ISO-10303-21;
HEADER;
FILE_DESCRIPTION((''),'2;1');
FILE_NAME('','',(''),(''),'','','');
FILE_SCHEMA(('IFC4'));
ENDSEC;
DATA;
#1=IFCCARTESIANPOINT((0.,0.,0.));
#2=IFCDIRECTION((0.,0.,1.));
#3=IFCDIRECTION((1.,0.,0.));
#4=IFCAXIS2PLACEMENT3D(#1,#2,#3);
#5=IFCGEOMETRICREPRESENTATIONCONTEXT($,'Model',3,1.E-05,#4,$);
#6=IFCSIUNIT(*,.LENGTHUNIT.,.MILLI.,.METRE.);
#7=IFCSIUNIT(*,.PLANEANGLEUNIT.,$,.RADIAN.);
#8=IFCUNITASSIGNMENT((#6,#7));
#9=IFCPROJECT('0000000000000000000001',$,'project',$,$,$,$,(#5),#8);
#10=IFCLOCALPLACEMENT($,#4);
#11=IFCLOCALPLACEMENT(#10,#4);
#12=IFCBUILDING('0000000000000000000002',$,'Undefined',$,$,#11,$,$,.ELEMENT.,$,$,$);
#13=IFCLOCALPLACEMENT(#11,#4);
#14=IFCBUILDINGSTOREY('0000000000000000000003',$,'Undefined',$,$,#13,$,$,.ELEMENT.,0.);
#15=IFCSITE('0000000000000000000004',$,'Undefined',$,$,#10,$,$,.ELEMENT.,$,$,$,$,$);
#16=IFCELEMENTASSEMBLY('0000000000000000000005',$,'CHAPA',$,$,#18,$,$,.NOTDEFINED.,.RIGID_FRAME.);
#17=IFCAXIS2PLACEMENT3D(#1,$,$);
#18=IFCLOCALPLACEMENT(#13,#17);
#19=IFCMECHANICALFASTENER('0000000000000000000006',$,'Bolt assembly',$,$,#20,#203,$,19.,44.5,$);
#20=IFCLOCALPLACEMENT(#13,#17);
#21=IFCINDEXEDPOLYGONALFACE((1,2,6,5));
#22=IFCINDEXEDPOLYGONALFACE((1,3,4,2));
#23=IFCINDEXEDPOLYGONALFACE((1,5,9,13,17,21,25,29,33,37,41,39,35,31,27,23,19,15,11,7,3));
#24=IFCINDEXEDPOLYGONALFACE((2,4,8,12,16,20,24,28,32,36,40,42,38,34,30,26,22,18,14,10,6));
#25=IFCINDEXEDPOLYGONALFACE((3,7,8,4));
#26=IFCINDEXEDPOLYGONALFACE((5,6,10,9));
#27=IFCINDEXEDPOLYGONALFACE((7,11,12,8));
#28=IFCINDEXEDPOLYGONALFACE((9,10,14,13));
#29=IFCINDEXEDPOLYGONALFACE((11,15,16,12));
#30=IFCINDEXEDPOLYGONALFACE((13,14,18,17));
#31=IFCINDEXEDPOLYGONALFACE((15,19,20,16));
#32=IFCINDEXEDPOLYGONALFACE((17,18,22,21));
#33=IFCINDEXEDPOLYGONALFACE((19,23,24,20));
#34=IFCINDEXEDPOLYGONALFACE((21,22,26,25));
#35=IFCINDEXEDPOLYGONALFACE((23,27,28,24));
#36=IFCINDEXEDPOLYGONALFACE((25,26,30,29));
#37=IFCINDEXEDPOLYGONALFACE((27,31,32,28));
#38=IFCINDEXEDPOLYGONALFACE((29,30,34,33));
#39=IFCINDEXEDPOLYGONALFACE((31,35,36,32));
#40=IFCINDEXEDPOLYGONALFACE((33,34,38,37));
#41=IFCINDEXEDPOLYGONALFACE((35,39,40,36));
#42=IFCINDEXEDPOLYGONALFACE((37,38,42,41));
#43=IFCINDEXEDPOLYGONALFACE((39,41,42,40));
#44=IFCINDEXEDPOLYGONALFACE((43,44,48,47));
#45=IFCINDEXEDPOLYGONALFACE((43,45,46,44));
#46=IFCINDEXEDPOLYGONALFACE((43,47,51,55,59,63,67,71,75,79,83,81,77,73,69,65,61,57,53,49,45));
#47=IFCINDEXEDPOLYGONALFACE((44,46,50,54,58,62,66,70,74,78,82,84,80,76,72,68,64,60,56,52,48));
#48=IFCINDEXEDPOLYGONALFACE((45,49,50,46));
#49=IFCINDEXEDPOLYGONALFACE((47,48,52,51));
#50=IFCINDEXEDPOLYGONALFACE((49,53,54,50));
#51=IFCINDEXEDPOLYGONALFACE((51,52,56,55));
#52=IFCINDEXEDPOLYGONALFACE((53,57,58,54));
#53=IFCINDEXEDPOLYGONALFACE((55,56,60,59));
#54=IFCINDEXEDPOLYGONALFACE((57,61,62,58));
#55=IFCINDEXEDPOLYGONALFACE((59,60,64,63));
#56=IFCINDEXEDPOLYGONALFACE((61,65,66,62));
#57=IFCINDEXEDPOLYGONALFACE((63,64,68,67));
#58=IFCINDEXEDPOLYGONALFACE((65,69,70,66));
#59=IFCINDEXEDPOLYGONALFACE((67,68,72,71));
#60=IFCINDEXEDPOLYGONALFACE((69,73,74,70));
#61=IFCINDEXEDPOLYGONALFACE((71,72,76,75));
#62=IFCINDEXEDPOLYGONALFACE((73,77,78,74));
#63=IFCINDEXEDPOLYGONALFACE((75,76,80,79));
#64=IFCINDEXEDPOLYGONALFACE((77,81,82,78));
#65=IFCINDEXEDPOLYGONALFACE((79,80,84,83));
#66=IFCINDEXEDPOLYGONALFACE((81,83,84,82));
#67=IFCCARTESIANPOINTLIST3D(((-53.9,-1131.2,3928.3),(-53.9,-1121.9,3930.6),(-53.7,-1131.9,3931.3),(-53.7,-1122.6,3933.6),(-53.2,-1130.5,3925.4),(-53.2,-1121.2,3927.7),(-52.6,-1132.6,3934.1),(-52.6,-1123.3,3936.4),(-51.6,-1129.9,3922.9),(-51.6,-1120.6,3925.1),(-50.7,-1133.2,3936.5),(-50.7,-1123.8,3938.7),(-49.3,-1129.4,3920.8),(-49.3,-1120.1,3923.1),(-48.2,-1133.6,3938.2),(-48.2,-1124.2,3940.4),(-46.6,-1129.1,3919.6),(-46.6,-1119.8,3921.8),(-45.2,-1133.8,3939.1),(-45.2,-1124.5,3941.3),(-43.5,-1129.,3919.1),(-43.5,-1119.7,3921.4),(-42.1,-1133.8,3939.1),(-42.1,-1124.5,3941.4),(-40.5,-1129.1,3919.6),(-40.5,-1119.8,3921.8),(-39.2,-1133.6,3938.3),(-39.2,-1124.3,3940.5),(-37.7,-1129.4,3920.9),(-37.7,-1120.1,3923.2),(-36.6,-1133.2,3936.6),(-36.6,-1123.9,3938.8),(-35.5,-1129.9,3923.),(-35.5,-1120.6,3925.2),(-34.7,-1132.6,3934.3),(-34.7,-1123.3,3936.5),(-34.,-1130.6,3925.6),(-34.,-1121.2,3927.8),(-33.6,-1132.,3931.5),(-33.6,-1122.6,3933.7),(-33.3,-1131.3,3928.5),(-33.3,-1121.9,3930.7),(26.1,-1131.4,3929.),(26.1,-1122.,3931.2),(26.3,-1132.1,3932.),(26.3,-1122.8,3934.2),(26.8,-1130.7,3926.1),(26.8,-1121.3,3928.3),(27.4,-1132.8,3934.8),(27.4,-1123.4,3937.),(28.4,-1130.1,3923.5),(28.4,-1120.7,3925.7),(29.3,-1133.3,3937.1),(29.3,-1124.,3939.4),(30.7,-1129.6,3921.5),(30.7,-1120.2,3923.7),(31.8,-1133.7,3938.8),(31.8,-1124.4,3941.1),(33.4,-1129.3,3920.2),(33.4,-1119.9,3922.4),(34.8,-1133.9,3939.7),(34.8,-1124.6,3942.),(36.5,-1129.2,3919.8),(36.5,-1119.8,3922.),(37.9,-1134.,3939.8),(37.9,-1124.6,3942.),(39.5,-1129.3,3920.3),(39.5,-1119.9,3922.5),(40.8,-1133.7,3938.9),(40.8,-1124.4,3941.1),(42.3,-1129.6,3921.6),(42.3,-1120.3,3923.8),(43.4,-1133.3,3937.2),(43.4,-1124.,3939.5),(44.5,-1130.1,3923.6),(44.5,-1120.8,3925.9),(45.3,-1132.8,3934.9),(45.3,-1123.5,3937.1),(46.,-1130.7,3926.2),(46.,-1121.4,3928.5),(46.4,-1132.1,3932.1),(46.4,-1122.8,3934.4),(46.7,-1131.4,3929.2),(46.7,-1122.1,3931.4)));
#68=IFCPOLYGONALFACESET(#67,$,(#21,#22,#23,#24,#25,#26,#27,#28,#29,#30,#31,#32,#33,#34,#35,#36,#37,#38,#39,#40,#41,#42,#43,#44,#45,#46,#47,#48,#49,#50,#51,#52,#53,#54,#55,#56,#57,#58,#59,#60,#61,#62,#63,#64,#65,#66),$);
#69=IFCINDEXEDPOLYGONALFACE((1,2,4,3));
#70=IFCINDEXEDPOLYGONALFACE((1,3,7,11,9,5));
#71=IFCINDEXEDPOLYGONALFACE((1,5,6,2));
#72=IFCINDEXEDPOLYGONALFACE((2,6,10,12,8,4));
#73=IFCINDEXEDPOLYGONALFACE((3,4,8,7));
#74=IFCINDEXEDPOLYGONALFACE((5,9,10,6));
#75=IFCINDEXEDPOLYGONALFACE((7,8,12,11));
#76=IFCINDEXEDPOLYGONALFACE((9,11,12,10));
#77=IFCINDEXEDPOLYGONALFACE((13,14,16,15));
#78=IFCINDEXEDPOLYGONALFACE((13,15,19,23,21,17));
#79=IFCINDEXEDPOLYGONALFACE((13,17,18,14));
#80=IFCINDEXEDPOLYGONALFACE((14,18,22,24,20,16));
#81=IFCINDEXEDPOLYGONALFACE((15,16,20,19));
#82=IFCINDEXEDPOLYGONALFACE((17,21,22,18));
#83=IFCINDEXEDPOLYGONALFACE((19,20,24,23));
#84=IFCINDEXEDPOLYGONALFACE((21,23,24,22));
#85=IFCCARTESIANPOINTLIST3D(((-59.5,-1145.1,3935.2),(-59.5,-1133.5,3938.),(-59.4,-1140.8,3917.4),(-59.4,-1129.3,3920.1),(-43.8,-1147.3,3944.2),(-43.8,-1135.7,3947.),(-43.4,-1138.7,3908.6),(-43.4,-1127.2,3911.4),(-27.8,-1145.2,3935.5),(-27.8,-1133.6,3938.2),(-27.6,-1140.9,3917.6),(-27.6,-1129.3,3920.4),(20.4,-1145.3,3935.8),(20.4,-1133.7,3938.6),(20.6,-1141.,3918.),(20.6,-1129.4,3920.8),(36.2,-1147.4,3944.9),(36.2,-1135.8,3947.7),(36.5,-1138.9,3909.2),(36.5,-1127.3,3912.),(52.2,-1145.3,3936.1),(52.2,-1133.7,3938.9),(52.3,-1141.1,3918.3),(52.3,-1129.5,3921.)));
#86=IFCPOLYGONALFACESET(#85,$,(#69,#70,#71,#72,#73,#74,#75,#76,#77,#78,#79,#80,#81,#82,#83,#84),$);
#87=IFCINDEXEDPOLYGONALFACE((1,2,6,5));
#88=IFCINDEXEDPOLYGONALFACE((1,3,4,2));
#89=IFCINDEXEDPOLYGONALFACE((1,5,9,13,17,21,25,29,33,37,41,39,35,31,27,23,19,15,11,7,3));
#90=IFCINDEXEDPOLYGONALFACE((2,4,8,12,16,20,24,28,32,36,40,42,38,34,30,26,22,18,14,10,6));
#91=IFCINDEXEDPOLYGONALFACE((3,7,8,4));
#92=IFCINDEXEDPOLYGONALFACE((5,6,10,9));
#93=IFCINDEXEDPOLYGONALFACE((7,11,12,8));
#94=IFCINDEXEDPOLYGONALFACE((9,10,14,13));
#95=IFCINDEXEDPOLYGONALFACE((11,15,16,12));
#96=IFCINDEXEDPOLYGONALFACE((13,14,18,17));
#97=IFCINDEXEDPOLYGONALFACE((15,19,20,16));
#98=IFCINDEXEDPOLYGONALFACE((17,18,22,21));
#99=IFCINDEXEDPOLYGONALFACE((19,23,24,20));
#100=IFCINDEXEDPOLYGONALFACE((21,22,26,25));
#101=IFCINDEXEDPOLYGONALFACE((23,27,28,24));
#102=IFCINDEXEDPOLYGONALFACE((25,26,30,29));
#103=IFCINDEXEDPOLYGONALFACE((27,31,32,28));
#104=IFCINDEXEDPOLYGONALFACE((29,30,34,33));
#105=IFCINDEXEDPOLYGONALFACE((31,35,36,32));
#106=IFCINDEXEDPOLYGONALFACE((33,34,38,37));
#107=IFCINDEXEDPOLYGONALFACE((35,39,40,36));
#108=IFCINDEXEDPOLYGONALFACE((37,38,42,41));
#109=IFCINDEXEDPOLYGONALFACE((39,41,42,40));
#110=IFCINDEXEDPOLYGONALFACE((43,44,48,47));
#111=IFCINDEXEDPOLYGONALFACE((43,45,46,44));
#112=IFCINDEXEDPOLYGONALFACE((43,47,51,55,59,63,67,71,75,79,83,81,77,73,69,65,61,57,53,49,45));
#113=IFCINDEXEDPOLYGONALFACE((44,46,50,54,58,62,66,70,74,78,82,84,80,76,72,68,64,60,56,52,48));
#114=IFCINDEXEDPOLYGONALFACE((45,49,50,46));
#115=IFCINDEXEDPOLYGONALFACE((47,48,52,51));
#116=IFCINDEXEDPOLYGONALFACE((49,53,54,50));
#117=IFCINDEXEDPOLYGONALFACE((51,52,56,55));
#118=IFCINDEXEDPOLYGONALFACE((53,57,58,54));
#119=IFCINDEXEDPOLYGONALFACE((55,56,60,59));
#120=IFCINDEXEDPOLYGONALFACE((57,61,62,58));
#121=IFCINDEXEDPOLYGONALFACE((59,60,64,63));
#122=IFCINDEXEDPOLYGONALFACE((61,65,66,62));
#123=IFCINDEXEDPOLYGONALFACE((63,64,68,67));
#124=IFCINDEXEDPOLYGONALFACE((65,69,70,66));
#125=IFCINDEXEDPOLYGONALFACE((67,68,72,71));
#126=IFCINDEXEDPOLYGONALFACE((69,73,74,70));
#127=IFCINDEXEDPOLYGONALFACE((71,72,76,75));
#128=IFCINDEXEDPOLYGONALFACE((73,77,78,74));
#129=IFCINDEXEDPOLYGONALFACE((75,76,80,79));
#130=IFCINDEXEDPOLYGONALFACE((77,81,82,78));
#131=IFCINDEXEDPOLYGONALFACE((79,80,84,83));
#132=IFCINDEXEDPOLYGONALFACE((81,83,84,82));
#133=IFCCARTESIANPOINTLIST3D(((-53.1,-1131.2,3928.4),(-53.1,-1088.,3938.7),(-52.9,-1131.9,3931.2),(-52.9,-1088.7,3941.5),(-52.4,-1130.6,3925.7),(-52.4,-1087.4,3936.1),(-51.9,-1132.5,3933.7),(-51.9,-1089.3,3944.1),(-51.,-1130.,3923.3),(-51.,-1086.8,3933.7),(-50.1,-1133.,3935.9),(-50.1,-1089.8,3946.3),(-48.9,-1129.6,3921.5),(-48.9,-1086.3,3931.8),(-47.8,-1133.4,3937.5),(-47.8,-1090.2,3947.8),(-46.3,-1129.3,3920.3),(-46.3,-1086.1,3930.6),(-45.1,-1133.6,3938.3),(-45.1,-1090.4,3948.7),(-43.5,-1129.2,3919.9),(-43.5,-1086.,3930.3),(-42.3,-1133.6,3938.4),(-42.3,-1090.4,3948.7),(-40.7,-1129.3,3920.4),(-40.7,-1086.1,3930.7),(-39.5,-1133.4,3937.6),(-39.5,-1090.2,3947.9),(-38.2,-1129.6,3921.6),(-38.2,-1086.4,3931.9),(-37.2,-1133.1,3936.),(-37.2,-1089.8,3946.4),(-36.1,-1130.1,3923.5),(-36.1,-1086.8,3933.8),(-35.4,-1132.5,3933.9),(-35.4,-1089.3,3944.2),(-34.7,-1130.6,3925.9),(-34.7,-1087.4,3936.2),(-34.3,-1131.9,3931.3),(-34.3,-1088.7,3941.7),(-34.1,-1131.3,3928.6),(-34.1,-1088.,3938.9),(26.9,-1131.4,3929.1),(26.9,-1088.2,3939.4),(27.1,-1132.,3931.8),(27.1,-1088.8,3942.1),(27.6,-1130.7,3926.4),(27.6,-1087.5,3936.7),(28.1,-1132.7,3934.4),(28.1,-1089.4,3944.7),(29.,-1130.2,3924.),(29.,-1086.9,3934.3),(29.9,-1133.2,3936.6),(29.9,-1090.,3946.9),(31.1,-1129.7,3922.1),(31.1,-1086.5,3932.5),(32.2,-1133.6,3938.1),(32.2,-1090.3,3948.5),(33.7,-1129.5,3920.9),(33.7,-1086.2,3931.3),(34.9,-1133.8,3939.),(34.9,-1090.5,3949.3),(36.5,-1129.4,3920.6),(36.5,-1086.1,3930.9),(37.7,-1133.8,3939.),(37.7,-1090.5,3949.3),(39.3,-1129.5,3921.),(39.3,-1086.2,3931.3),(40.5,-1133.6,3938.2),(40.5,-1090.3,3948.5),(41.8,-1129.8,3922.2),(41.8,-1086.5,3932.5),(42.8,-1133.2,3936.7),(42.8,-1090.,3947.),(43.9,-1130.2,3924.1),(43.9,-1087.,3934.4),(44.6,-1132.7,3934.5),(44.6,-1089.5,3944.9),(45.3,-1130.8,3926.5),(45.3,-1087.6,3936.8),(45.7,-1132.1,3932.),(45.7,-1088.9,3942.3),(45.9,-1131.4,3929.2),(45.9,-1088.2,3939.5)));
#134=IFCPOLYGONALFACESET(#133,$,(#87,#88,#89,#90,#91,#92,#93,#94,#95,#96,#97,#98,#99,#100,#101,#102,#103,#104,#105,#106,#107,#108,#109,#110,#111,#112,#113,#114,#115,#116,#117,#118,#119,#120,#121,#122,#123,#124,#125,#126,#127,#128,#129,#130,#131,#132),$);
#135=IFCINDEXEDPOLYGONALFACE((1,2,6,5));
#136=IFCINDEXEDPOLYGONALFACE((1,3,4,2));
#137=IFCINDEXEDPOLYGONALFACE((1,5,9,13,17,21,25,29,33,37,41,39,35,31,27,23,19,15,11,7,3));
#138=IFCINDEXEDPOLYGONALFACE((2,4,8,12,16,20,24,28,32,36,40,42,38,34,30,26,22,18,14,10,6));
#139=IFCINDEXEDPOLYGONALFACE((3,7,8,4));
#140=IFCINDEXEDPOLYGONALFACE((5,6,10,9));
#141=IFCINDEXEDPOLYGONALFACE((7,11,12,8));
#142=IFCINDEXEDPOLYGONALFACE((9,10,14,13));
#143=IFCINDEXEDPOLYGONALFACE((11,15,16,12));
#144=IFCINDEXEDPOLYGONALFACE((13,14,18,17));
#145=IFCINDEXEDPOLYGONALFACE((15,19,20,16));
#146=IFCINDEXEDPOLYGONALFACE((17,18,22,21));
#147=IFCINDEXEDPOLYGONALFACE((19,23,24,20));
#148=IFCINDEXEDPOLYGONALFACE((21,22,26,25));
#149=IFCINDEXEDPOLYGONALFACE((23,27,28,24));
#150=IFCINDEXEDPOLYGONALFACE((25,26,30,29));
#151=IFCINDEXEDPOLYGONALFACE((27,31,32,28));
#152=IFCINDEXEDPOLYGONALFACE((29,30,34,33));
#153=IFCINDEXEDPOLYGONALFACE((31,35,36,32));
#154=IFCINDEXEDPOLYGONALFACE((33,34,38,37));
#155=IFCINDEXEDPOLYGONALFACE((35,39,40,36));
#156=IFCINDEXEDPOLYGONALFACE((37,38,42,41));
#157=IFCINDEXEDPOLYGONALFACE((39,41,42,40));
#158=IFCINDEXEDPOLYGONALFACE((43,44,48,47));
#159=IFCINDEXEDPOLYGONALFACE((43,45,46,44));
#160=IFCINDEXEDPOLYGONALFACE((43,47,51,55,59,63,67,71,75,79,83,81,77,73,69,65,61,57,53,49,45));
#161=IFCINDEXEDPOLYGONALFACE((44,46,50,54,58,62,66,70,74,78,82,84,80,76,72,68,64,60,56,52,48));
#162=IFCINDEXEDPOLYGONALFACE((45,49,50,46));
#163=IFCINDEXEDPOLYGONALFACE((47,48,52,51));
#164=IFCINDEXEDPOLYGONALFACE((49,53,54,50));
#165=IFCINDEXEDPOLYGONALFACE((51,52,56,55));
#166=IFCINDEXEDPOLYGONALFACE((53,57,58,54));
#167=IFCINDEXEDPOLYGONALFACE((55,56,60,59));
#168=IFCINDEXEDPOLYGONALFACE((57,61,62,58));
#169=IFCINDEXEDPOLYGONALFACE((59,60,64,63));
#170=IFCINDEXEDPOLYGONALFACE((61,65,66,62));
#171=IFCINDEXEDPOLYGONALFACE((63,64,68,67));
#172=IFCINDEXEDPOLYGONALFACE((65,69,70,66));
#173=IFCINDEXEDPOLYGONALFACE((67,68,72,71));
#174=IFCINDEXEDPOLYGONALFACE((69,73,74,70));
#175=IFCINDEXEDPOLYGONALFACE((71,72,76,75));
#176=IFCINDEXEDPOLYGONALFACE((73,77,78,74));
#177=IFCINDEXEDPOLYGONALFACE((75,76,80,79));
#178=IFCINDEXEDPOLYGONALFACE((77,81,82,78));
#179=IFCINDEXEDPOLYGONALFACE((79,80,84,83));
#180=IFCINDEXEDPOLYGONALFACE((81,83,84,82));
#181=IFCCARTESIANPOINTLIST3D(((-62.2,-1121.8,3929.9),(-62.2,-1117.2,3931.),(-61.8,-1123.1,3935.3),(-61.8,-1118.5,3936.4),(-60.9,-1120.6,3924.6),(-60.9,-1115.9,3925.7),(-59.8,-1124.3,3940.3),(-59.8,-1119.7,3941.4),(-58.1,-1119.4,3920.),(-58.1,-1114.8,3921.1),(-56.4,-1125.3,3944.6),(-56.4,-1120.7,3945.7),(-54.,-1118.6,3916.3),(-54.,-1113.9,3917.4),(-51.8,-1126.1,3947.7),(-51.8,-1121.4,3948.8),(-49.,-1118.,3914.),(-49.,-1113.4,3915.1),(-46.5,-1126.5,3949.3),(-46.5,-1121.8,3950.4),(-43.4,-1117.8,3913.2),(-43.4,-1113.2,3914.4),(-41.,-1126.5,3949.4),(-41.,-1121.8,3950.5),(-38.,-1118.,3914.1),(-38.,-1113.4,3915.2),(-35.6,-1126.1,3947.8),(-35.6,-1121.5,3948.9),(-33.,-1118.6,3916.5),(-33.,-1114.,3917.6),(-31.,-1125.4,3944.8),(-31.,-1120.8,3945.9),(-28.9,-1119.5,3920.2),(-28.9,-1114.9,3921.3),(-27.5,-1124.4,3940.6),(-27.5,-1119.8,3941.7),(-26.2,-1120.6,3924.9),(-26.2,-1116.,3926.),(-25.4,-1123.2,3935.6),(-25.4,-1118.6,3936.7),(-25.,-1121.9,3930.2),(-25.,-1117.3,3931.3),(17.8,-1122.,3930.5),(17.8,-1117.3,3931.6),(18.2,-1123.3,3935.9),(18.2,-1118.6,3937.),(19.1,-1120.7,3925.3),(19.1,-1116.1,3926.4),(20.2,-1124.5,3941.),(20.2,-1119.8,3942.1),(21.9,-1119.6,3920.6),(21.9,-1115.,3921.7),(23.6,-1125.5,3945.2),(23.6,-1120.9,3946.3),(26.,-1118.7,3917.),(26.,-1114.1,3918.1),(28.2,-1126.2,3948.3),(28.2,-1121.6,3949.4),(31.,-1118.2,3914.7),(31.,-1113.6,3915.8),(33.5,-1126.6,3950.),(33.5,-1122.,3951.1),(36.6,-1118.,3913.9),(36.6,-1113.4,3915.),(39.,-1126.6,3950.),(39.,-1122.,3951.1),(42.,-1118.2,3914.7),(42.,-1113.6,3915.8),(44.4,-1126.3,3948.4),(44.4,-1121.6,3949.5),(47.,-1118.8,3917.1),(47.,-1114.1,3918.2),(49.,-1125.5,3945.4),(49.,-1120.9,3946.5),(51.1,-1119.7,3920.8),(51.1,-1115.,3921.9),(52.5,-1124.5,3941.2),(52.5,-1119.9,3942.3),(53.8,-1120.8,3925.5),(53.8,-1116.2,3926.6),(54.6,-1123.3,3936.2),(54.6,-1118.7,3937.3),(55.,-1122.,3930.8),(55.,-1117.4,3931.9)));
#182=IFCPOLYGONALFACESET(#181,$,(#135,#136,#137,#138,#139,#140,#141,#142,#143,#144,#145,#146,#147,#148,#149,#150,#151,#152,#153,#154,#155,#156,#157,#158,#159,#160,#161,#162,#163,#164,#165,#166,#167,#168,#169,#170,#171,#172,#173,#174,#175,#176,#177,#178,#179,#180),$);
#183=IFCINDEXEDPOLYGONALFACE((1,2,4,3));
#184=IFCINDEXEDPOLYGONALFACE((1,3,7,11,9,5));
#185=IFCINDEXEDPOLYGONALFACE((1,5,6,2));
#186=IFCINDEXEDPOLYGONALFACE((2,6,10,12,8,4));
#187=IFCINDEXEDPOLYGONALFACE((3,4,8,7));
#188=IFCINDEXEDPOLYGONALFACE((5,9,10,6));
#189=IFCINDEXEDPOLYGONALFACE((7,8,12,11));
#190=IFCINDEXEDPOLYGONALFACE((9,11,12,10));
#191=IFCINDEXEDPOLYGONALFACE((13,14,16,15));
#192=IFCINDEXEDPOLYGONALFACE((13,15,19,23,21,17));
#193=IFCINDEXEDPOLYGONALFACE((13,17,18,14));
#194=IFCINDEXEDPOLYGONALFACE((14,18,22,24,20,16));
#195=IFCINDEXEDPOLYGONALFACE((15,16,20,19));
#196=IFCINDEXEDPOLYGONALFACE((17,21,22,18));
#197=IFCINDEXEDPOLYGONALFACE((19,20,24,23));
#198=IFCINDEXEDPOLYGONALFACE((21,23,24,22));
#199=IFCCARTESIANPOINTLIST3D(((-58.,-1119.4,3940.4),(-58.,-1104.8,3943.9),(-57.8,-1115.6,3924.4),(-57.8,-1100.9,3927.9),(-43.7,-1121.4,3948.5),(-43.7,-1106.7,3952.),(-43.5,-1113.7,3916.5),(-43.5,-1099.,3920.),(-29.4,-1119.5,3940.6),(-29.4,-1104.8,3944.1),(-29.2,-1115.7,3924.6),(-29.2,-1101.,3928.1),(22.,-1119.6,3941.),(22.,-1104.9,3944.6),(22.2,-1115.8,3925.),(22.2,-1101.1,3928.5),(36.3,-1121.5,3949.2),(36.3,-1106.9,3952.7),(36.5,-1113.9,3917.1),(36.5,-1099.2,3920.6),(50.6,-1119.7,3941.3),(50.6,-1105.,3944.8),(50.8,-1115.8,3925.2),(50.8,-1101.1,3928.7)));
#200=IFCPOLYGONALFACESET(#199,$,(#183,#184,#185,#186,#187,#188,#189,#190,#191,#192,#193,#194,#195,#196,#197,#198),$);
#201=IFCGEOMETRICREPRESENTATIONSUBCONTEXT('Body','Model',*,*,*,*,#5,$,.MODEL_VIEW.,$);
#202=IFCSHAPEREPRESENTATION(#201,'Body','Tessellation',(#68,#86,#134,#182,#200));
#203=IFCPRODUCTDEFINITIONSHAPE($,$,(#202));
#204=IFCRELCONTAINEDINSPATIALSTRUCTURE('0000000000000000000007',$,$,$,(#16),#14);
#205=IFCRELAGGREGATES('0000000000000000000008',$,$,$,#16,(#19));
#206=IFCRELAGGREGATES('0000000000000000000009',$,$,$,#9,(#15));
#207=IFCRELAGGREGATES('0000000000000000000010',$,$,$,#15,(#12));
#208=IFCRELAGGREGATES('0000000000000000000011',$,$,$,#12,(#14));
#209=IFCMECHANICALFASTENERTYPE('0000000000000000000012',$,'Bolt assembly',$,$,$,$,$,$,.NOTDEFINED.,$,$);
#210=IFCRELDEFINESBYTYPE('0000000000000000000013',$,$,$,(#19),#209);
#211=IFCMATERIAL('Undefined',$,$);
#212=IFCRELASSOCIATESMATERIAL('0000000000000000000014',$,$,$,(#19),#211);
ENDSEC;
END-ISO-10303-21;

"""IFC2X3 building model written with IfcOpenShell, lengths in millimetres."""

from ifc_helpers import new_model, si_unit, frame, origin_with_axes, origin_2d_with_axis, place, context, subcontext, project, spatial, polyline, circle, outline, extrude, source, transform, mapped, material, type_object, element, aggregate, save


model = new_model("IFC2X3")

# Units and contexts
model_context = context("Model", 3, precision=1e-05, world=origin_with_axes())
body_context = subcontext(model_context, "Body", "Model", "MODEL_VIEW")
ifc_project = project(units=[si_unit("LENGTHUNIT", "METRE", prefix="MILLI"), si_unit("PLANEANGLEUNIT", "RADIAN")], contexts=[model_context])

# Site, building, storey
site_placement = place(None, origin_with_axes())
site = spatial("IfcSite", under=ifc_project, at=site_placement, Name="Undefined", CompositionType="ELEMENT")
building_placement = place(site_placement, origin_with_axes())
building = spatial("IfcBuilding", under=site, at=building_placement, Name="Undefined", CompositionType="ELEMENT")
storey_placement = place(building_placement, origin_with_axes())
storey = spatial("IfcBuildingStorey", under=building, at=storey_placement, Name="Undefined", CompositionType="ELEMENT", Elevation=0.0)

# Element assembly
assembly_1_placement = place(storey_placement, origin_with_axes())
assembly_1 = element("IfcElementAssembly", 1, at=assembly_1_placement, inside=storey, Name="CHAPA", AssemblyPlace="NOTDEFINED", PredefinedType="RIGID_FRAME")

# Shared definitions
ifc_material_1 = material(Name="Undefined")
mechanical_fastener_type = type_object("IfcMechanicalFastenerType", Name="Bolt assembly")

# Mechanical fastener
shared_shape_1 = source(origin_with_axes(), body_context, "Body", "SweptSolid", [
    extrude(circle(Radius=10.3, at=origin_2d_with_axis()), frame((0.0, 0.0, 0.0), z_axis=(0.0, 1.0, 0.0), x_axis=(1.0, 0.0, 0.0)), (0.0, 0.0, 1.0), 9.6),
    extrude(outline(polyline([(18.3, 0.0), (9.2, 15.9), (-9.2, 15.9), (-18.3, 0.0), (-9.2, -15.9), (9.2, -15.9), (18.3, 0.0)])), frame((0.0, -11.9, 0.0), z_axis=(0.0, 1.0, 0.0), x_axis=(1.0, 0.0, 0.0)), (0.0, 0.0, 1.0), 11.9),
    extrude(circle(Radius=9.5, at=origin_2d_with_axis()), frame((0.0, 0.0, 0.0), z_axis=(0.0, 1.0, 0.0), x_axis=(1.0, 0.0, 0.0)), (0.0, 0.0, 1.0), 44.5),
    extrude(circle(Radius=18.7, at=origin_2d_with_axis()), frame((0.0, 9.5, 0.0), z_axis=(0.0, 1.0, 0.0), x_axis=(1.0, 0.0, 0.0)), (0.0, 0.0, 1.0), 4.8),
    extrude(outline(polyline([(16.5, 0.0), (8.2, 14.3), (-8.2, 14.3), (-16.5, 0.0), (-8.2, -14.3), (8.2, -14.3), (16.5, 0.0)])), frame((0.0, 14.3, 0.0), z_axis=(0.0, 1.0, 0.0), x_axis=(1.0, 0.0, 0.0)), (0.0, 0.0, 1.0), 15.1),
])
mechanical_fastener_1_placement = place(assembly_1_placement, frame((-3.6, -1131.5, 3929.5), z_axis=(0.999966, -0.001918, 0.008027), x_axis=(0.008253, 0.23249, -0.972564)))
mechanical_fastener_1 = element("IfcMechanicalFastener", 2, at=mechanical_fastener_1_placement, type_object=mechanical_fastener_type, material=ifc_material_1, Name="Bolt assembly", NominalDiameter=19.0, NominalLength=44.5, context=body_context, shape_type="MappedRepresentation", body=[
    mapped(shared_shape_1, transform((0.0, 0.0, -40.0))),
    mapped(shared_shape_1, transform((0.0, 0.0, 40.0))),
])
aggregate(assembly_1, [mechanical_fastener_1])

save(model, "model.ifc")
